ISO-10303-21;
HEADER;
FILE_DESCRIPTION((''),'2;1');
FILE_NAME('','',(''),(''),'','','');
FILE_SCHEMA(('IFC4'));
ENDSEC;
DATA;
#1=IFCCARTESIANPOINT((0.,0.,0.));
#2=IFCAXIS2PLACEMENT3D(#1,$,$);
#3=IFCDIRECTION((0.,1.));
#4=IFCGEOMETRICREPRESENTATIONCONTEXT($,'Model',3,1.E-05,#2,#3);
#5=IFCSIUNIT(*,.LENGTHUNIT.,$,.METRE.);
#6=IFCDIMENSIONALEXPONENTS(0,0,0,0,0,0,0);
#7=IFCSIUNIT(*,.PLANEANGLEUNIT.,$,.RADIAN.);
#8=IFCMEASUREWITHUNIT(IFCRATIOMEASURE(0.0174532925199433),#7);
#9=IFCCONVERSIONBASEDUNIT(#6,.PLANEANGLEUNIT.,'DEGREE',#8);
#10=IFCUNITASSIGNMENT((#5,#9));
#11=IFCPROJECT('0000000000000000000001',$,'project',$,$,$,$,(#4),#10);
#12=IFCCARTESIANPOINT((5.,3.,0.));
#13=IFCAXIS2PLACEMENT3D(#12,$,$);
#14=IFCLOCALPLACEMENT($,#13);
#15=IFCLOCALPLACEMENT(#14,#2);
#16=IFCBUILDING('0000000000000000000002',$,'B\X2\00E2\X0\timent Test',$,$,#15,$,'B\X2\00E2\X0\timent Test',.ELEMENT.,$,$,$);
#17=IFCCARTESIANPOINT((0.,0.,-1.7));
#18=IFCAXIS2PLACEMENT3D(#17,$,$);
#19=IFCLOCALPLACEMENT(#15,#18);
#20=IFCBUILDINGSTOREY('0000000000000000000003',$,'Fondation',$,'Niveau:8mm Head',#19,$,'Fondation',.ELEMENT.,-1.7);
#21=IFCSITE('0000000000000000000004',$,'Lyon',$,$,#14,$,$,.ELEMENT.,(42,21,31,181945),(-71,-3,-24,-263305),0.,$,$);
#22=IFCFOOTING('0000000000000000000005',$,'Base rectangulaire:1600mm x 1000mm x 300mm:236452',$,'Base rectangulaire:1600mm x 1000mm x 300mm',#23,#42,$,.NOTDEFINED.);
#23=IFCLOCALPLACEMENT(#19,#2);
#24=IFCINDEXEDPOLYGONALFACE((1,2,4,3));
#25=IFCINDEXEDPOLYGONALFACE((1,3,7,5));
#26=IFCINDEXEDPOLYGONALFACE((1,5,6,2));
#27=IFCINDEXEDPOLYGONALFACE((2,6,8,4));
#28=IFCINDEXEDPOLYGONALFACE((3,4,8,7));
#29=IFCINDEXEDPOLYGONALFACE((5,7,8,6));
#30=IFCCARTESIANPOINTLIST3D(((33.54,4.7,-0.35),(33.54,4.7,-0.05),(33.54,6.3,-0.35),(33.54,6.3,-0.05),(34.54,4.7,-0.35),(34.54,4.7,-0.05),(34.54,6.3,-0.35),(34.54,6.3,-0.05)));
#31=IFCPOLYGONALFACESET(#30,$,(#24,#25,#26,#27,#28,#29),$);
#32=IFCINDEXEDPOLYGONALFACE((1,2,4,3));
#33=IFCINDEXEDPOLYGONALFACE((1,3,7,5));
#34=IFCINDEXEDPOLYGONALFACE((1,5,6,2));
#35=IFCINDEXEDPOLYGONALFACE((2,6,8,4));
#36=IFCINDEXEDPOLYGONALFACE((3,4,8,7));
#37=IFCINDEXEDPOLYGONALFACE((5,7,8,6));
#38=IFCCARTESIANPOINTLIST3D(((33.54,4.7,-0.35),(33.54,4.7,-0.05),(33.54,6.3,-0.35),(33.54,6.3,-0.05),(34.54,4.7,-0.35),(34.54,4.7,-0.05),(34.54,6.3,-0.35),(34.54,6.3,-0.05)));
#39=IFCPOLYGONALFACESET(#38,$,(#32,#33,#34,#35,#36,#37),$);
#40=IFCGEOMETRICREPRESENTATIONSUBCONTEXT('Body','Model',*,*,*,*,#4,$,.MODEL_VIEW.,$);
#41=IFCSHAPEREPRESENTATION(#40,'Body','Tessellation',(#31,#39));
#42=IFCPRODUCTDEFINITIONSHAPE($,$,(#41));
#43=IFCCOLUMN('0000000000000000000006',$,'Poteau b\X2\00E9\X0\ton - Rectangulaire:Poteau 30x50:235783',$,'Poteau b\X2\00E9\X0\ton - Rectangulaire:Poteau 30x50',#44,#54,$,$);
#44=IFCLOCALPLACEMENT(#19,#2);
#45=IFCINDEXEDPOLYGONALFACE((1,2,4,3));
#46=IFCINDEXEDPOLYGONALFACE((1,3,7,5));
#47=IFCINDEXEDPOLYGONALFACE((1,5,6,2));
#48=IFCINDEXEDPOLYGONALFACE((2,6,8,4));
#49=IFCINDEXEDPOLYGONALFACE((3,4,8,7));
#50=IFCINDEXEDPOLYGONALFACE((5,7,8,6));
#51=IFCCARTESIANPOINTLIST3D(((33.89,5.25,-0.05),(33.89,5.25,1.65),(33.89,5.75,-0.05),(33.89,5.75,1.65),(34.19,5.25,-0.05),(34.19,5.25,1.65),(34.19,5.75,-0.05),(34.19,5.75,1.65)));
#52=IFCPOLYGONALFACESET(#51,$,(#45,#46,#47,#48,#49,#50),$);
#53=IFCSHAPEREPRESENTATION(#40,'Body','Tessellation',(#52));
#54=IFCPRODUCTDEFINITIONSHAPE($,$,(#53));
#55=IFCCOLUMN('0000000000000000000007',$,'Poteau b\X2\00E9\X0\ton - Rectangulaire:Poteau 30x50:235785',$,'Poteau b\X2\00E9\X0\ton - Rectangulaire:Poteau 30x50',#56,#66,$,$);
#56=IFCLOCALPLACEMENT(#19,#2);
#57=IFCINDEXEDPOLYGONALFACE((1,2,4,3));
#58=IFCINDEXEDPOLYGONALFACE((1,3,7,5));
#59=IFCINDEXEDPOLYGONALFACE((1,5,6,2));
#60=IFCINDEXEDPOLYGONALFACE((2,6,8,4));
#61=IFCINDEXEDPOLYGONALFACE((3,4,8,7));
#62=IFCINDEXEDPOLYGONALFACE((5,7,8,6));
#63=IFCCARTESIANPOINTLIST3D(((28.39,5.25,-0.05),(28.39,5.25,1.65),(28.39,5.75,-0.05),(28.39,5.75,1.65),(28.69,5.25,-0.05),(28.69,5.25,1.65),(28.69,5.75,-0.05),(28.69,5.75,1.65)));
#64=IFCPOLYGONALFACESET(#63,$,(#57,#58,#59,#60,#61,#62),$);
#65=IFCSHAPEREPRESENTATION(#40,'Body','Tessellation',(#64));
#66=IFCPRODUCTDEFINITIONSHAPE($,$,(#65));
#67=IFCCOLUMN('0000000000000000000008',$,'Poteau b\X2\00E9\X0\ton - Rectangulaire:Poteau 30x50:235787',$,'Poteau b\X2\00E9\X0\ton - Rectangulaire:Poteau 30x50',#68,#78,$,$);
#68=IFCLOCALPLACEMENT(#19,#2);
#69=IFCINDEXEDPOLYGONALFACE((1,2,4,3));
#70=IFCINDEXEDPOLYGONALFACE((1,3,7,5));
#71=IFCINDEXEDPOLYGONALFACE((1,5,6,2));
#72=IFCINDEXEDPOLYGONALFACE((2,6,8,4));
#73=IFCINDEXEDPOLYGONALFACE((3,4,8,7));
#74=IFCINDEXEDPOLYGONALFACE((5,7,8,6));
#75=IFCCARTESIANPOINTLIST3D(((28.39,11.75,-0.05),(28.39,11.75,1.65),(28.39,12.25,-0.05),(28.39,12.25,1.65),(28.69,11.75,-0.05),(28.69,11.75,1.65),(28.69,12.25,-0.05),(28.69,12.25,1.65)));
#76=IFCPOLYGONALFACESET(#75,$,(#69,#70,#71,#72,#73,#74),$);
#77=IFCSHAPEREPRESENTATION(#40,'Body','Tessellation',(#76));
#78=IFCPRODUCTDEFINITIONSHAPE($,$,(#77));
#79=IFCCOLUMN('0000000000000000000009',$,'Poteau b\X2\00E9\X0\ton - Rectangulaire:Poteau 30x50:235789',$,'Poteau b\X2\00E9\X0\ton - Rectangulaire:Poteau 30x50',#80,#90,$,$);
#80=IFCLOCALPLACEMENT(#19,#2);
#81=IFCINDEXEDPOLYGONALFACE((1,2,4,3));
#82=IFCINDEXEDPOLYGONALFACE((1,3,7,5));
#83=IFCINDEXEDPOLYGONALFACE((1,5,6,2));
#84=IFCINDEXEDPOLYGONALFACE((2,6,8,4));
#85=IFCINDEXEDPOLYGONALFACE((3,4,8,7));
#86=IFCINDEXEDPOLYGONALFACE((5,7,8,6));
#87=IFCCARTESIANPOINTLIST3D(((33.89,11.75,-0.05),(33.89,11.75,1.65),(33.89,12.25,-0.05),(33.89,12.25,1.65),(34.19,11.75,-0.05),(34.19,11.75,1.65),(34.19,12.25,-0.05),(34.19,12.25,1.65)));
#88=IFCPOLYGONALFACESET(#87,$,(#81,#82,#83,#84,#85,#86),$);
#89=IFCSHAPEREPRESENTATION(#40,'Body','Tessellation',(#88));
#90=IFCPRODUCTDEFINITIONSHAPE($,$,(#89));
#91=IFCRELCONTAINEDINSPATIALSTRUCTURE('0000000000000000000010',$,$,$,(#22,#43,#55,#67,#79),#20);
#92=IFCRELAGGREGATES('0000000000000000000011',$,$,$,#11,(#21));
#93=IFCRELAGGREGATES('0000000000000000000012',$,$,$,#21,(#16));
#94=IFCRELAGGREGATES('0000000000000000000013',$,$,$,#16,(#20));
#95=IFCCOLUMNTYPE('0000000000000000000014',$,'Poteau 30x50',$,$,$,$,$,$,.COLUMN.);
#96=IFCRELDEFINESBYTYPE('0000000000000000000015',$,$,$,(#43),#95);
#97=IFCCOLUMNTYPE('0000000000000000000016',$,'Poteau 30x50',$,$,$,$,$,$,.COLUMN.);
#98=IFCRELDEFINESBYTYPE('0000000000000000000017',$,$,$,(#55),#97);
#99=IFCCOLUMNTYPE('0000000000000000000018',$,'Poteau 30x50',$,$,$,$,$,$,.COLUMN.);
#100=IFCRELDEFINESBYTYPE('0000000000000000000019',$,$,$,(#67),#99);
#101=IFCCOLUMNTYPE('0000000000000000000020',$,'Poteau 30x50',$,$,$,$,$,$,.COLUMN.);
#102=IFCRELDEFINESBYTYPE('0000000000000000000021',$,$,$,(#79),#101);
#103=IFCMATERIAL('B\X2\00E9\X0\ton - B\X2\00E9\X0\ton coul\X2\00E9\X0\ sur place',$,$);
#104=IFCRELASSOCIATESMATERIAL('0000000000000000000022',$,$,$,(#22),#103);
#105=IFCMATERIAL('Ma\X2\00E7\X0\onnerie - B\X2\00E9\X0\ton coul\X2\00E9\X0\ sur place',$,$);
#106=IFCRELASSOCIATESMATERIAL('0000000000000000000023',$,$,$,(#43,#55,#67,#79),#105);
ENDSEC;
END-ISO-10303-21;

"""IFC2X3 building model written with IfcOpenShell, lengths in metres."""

from ifc_helpers import new_model, entity, si_unit, converted_unit, direction, frame, origin, origin_2d_with_axis, place, context, subcontext, project, spatial, rectangle, extrude, source, transform, mapped, material, type_object, type_shapes, element, save


model = new_model("IFC2X3")

# Units and contexts
model_context = context("Model", 3, precision=1e-05, world=origin(), true_north=direction((0.0, 1.0)))
body_context = subcontext(model_context, "Body", "Model", "MODEL_VIEW")
ifc_project = project(units=[si_unit("LENGTHUNIT", "METRE"), converted_unit("PLANEANGLEUNIT", "DEGREE", entity("IfcRatioMeasure", 0.0174532925199433), si_unit("PLANEANGLEUNIT", "RADIAN"), dimensions=[0, 0, 0, 0, 0, 0, 0])], contexts=[model_context])

# Site, building, storey
site_placement = place(None, frame((5.0, 3.0, 0.0)))
site = spatial("IfcSite", under=ifc_project, at=site_placement, Name="Lyon", CompositionType="ELEMENT", RefLatitude=(42, 21, 31, 181945), RefLongitude=(-71, -3, -24, -263305), RefElevation=0.0)
building_placement = place(site_placement, origin())
building = spatial("IfcBuilding", under=site, at=building_placement, Name="Bâtiment Test", LongName="Bâtiment Test", CompositionType="ELEMENT")
storey_placement = place(building_placement, frame((0.0, 0.0, -1.7)))
storey = spatial("IfcBuildingStorey", under=building, at=storey_placement, Name="Fondation", ObjectType="Niveau:8mm Head", LongName="Fondation", CompositionType="ELEMENT", Elevation=-1.7)

# Footing
ifc_material_1 = material(Name="Béton - Béton coulé sur place")
footing_1_placement = place(storey_placement, origin())
element("IfcFooting", 1, at=footing_1_placement, inside=storey, material=ifc_material_1, Name="Base rectangulaire:1600mm x 1000mm x 300mm:236452", ObjectType="Base rectangulaire:1600mm x 1000mm x 300mm", PredefinedType="NOTDEFINED", context=body_context, shape_type="SweptSolid", body=[
    extrude(rectangle(XDim=1.0, YDim=1.6, at=origin_2d_with_axis()), frame((34.04, 5.5, -0.35), z_axis=(0.0, 0.0, 1.0), x_axis=(-1.0, 0.0, 0.0)), (0.0, 0.0, 1.0), 0.3),
    extrude(rectangle(XDim=1.0, YDim=1.6, at=origin_2d_with_axis()), frame((34.04, 5.5, -0.35), z_axis=(0.0, 0.0, 1.0), x_axis=(-1.0, 0.0, 0.0)), (0.0, 0.0, 1.0), 0.3),
])

# Columns
ifc_material_2 = material(Name="Maçonnerie - Béton coulé sur place")
column_type_1 = type_object("IfcColumnType", Name="Poteau 30x50", PredefinedType="COLUMN")
shared_shape_1 = source(origin(), body_context, "Body", "SweptSolid", [
    extrude(rectangle(XDim=0.5, YDim=0.3, at=origin_2d_with_axis()), frame((34.04, 5.5, -1.75), z_axis=(0.0, 0.0, 1.0), x_axis=(0.0, -1.0, 0.0)), (0.0, 0.0, 1.0), 1.7),
])
type_shapes(column_type_1, [shared_shape_1])
column_1_placement = place(storey_placement, frame((0.0, 0.0, 1.7)))
element("IfcColumn", 2, at=column_1_placement, inside=storey, type_object=column_type_1, material=ifc_material_2, Name="Poteau béton - Rectangulaire:Poteau 30x50:235783", ObjectType="Poteau béton - Rectangulaire:Poteau 30x50", context=body_context, shape_type="MappedRepresentation", body=[
    mapped(shared_shape_1, transform((0.0, 0.0, 0.0), scale=1.0)),
])
column_type_2 = type_object("IfcColumnType", Name="Poteau 30x50", PredefinedType="COLUMN")
shared_shape_2 = source(origin(), body_context, "Body", "SweptSolid", [
    extrude(rectangle(XDim=0.5, YDim=0.3, at=origin_2d_with_axis()), frame((28.54, 5.5, -1.75), z_axis=(0.0, 0.0, 1.0), x_axis=(0.0, -1.0, 0.0)), (0.0, 0.0, 1.0), 1.7),
])
type_shapes(column_type_2, [shared_shape_2])
column_2_placement = place(storey_placement, frame((0.0, 0.0, 1.7)))
element("IfcColumn", 3, at=column_2_placement, inside=storey, type_object=column_type_2, material=ifc_material_2, Name="Poteau béton - Rectangulaire:Poteau 30x50:235785", ObjectType="Poteau béton - Rectangulaire:Poteau 30x50", context=body_context, shape_type="MappedRepresentation", body=[
    mapped(shared_shape_2, transform((0.0, 0.0, 0.0), scale=1.0)),
])
column_type_3 = type_object("IfcColumnType", Name="Poteau 30x50", PredefinedType="COLUMN")
shared_shape_3 = source(origin(), body_context, "Body", "SweptSolid", [
    extrude(rectangle(XDim=0.5, YDim=0.3, at=origin_2d_with_axis()), frame((28.54, 12.0, -1.75), z_axis=(0.0, 0.0, 1.0), x_axis=(0.0, -1.0, 0.0)), (0.0, 0.0, 1.0), 1.7),
])
type_shapes(column_type_3, [shared_shape_3])
column_3_placement = place(storey_placement, frame((0.0, 0.0, 1.7)))
element("IfcColumn", 4, at=column_3_placement, inside=storey, type_object=column_type_3, material=ifc_material_2, Name="Poteau béton - Rectangulaire:Poteau 30x50:235787", ObjectType="Poteau béton - Rectangulaire:Poteau 30x50", context=body_context, shape_type="MappedRepresentation", body=[
    mapped(shared_shape_3, transform((0.0, 0.0, 0.0), scale=1.0)),
])
column_type_4 = type_object("IfcColumnType", Name="Poteau 30x50", PredefinedType="COLUMN")
shared_shape_4 = source(origin(), body_context, "Body", "SweptSolid", [
    extrude(rectangle(XDim=0.5, YDim=0.3, at=origin_2d_with_axis()), frame((34.04, 12.0, -1.75), z_axis=(0.0, 0.0, 1.0), x_axis=(0.0, -1.0, 0.0)), (0.0, 0.0, 1.0), 1.7),
])
type_shapes(column_type_4, [shared_shape_4])
column_4_placement = place(storey_placement, frame((0.0, 0.0, 1.7)))
element("IfcColumn", 5, at=column_4_placement, inside=storey, type_object=column_type_4, material=ifc_material_2, Name="Poteau béton - Rectangulaire:Poteau 30x50:235789", ObjectType="Poteau béton - Rectangulaire:Poteau 30x50", context=body_context, shape_type="MappedRepresentation", body=[
    mapped(shared_shape_4, transform((0.0, 0.0, 0.0), scale=1.0)),
])

save(model, "model.ifc")
